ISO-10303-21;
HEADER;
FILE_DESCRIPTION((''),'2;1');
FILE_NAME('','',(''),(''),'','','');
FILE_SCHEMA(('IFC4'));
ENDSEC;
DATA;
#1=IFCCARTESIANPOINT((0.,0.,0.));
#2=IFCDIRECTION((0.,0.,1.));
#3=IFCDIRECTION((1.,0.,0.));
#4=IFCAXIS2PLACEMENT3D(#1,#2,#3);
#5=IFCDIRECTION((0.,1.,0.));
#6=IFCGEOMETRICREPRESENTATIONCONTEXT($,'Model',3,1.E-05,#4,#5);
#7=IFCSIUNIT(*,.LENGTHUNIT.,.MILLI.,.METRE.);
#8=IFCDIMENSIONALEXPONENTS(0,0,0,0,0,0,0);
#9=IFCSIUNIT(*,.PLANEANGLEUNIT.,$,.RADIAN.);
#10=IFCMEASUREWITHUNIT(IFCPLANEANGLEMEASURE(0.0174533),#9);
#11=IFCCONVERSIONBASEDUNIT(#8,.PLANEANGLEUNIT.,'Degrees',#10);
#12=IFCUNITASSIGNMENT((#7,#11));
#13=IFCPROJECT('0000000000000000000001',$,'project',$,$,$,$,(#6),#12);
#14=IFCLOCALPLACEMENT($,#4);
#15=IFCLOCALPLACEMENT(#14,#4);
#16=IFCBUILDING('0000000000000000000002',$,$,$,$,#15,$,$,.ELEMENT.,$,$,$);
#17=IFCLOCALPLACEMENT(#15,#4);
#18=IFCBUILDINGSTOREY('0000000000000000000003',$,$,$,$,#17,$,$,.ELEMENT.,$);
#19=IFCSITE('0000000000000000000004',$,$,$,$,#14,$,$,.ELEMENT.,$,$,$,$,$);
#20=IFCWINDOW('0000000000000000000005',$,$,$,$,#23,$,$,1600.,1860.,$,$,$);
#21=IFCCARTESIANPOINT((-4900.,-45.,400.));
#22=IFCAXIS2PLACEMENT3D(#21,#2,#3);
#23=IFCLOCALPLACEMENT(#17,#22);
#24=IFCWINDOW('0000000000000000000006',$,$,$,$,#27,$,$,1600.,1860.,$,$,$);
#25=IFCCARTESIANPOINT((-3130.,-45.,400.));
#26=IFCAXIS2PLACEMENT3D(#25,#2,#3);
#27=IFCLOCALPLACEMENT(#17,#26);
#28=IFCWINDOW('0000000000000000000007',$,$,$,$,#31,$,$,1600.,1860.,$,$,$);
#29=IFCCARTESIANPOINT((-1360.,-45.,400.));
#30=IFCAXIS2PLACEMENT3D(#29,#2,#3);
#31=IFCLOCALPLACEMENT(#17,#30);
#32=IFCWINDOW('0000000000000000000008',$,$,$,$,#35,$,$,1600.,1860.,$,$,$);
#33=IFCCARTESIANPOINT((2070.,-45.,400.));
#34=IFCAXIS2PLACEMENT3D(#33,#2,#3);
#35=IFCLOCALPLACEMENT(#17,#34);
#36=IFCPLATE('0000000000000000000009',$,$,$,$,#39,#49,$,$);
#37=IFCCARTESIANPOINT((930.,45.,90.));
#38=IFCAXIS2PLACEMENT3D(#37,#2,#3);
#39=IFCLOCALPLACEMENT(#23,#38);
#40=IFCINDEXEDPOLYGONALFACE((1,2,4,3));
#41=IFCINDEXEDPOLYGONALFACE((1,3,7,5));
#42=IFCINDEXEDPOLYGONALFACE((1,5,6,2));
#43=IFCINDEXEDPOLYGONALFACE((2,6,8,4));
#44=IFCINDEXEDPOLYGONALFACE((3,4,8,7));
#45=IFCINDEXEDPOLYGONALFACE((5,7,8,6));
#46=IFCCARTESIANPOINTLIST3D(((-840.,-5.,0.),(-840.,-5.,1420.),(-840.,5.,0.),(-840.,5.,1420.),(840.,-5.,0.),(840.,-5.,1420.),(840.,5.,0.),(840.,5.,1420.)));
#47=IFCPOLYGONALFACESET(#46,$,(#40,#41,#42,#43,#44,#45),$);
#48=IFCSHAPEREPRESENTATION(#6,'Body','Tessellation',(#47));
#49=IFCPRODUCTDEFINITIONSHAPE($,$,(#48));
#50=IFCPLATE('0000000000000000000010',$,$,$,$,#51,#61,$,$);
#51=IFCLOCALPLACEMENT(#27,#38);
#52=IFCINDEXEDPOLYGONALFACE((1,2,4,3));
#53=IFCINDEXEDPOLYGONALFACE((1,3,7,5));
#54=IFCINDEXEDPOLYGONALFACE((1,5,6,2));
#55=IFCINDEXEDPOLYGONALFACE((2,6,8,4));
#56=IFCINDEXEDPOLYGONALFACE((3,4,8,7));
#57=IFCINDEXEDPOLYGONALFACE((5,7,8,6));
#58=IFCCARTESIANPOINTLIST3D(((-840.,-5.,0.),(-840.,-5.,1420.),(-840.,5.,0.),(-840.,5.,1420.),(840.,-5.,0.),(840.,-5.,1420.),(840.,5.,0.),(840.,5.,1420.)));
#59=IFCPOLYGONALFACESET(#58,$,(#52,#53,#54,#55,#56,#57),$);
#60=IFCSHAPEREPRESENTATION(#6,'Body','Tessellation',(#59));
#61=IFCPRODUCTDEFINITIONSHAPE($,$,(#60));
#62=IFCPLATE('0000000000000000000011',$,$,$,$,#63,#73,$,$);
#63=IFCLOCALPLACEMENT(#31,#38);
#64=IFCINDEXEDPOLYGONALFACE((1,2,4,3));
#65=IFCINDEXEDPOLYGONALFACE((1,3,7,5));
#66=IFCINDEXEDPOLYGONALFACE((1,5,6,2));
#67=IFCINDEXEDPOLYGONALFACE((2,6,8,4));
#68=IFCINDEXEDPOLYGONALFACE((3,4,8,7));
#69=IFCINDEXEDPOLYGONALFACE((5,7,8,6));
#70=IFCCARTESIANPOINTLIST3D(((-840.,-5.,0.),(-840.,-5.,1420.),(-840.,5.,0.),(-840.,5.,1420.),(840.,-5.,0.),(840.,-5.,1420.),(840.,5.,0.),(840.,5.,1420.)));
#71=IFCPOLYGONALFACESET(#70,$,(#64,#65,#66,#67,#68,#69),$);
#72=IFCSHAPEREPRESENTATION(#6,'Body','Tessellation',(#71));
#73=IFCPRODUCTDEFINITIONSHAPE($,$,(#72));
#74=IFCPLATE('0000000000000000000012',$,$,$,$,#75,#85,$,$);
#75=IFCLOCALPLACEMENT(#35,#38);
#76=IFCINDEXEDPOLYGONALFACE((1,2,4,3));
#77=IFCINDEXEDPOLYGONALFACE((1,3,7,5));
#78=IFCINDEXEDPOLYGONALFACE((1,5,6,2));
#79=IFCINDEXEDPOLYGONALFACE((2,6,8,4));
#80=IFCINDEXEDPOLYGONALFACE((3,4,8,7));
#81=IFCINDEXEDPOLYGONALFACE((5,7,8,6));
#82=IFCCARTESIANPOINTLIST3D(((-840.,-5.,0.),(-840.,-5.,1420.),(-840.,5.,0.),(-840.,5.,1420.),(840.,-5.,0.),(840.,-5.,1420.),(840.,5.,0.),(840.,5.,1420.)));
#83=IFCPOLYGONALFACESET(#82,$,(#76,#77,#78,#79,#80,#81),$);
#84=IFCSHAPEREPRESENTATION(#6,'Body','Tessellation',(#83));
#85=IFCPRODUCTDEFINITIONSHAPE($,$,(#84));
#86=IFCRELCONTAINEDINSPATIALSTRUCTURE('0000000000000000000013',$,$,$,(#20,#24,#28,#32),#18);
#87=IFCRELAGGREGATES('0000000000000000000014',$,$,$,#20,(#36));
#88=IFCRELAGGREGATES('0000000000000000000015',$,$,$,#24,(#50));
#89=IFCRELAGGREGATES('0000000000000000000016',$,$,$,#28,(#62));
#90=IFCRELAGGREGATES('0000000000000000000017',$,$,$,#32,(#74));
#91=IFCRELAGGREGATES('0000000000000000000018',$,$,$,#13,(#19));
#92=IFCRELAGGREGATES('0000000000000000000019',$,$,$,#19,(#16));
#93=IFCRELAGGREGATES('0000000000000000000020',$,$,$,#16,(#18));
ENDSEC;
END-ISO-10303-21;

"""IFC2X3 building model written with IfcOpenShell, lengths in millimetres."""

from ifc_helpers import new_model, entity, si_unit, converted_unit, direction, frame, origin_with_axes, place, context, project, spatial, polyline, outline, extrude, element, aggregate, save


model = new_model("IFC2X3")

# Units and contexts
model_context = context("Model", 3, precision=1e-05, world=origin_with_axes(), true_north=direction((0.0, 1.0, 0.0)))
ifc_project = project(units=[si_unit("LENGTHUNIT", "METRE", prefix="MILLI"), converted_unit("PLANEANGLEUNIT", "Degrees", entity("IfcPlaneAngleMeasure", 0.0174533), si_unit("PLANEANGLEUNIT", "RADIAN"), dimensions=[0, 0, 0, 0, 0, 0, 0])], contexts=[model_context])

# Site, building, storey
site_placement = place(None, origin_with_axes())
site = spatial("IfcSite", under=ifc_project, at=site_placement, CompositionType="ELEMENT")
building_placement = place(site_placement, origin_with_axes())
building = spatial("IfcBuilding", under=site, at=building_placement, CompositionType="ELEMENT")
storey_placement = place(building_placement, origin_with_axes())
storey = spatial("IfcBuildingStorey", under=building, at=storey_placement, CompositionType="ELEMENT")

# Windows
window_1_placement = place(storey_placement, frame((-4900.0, -45.0, 400.0), z_axis=(0.0, 0.0, 1.0), x_axis=(1.0, 0.0, 0.0)))
window_1 = element("IfcWindow", 1, at=window_1_placement, inside=storey, OverallHeight=1600.0, OverallWidth=1860.0)
window_2_placement = place(storey_placement, frame((-3130.0, -45.0, 400.0), z_axis=(0.0, 0.0, 1.0), x_axis=(1.0, 0.0, 0.0)))
window_2 = element("IfcWindow", 2, at=window_2_placement, inside=storey, OverallHeight=1600.0, OverallWidth=1860.0)
window_3_placement = place(storey_placement, frame((-1360.0, -45.0, 400.0), z_axis=(0.0, 0.0, 1.0), x_axis=(1.0, 0.0, 0.0)))
window_3 = element("IfcWindow", 3, at=window_3_placement, inside=storey, OverallHeight=1600.0, OverallWidth=1860.0)
window_4_placement = place(storey_placement, frame((2070.0, -45.0, 400.0), z_axis=(0.0, 0.0, 1.0), x_axis=(1.0, 0.0, 0.0)))
window_4 = element("IfcWindow", 4, at=window_4_placement, inside=storey, OverallHeight=1600.0, OverallWidth=1860.0)

# Plates
plate_1_placement = place(window_1_placement, frame((930.0, 45.0, 90.0), z_axis=(0.0, 0.0, 1.0), x_axis=(1.0, 0.0, 0.0)))
plate_1 = element("IfcPlate", 5, at=plate_1_placement, context=model_context, shape_type="SweptSolid", body=[
    extrude(outline(polyline([(-840.0, -5.0), (840.0, -5.0), (840.0, 5.0), (-840.0, 5.0), (-840.0, -5.0), (-840.0, -5.0)])), origin_with_axes(), (0.0, 0.0, 1.0), 1420.0),
])
aggregate(window_1, [plate_1])
plate_2_placement = place(window_2_placement, frame((930.0, 45.0, 90.0), z_axis=(0.0, 0.0, 1.0), x_axis=(1.0, 0.0, 0.0)))
plate_2 = element("IfcPlate", 6, at=plate_2_placement, context=model_context, shape_type="SweptSolid", body=[
    extrude(outline(polyline([(-840.0, -5.0), (840.0, -5.0), (840.0, 5.0), (-840.0, 5.0), (-840.0, -5.0), (-840.0, -5.0)])), origin_with_axes(), (0.0, 0.0, 1.0), 1420.0),
])
aggregate(window_2, [plate_2])
plate_3_placement = place(window_3_placement, frame((930.0, 45.0, 90.0), z_axis=(0.0, 0.0, 1.0), x_axis=(1.0, 0.0, 0.0)))
plate_3 = element("IfcPlate", 7, at=plate_3_placement, context=model_context, shape_type="SweptSolid", body=[
    extrude(outline(polyline([(-840.0, -5.0), (840.0, -5.0), (840.0, 5.0), (-840.0, 5.0), (-840.0, -5.0), (-840.0, -5.0)])), origin_with_axes(), (0.0, 0.0, 1.0), 1420.0),
])
aggregate(window_3, [plate_3])
plate_4_placement = place(window_4_placement, frame((930.0, 45.0, 90.0), z_axis=(0.0, 0.0, 1.0), x_axis=(1.0, 0.0, 0.0)))
plate_4 = element("IfcPlate", 8, at=plate_4_placement, context=model_context, shape_type="SweptSolid", body=[
    extrude(outline(polyline([(-840.0, -5.0), (840.0, -5.0), (840.0, 5.0), (-840.0, 5.0), (-840.0, -5.0), (-840.0, -5.0)])), origin_with_axes(), (0.0, 0.0, 1.0), 1420.0),
])
aggregate(window_4, [plate_4])

save(model, "model.ifc")
